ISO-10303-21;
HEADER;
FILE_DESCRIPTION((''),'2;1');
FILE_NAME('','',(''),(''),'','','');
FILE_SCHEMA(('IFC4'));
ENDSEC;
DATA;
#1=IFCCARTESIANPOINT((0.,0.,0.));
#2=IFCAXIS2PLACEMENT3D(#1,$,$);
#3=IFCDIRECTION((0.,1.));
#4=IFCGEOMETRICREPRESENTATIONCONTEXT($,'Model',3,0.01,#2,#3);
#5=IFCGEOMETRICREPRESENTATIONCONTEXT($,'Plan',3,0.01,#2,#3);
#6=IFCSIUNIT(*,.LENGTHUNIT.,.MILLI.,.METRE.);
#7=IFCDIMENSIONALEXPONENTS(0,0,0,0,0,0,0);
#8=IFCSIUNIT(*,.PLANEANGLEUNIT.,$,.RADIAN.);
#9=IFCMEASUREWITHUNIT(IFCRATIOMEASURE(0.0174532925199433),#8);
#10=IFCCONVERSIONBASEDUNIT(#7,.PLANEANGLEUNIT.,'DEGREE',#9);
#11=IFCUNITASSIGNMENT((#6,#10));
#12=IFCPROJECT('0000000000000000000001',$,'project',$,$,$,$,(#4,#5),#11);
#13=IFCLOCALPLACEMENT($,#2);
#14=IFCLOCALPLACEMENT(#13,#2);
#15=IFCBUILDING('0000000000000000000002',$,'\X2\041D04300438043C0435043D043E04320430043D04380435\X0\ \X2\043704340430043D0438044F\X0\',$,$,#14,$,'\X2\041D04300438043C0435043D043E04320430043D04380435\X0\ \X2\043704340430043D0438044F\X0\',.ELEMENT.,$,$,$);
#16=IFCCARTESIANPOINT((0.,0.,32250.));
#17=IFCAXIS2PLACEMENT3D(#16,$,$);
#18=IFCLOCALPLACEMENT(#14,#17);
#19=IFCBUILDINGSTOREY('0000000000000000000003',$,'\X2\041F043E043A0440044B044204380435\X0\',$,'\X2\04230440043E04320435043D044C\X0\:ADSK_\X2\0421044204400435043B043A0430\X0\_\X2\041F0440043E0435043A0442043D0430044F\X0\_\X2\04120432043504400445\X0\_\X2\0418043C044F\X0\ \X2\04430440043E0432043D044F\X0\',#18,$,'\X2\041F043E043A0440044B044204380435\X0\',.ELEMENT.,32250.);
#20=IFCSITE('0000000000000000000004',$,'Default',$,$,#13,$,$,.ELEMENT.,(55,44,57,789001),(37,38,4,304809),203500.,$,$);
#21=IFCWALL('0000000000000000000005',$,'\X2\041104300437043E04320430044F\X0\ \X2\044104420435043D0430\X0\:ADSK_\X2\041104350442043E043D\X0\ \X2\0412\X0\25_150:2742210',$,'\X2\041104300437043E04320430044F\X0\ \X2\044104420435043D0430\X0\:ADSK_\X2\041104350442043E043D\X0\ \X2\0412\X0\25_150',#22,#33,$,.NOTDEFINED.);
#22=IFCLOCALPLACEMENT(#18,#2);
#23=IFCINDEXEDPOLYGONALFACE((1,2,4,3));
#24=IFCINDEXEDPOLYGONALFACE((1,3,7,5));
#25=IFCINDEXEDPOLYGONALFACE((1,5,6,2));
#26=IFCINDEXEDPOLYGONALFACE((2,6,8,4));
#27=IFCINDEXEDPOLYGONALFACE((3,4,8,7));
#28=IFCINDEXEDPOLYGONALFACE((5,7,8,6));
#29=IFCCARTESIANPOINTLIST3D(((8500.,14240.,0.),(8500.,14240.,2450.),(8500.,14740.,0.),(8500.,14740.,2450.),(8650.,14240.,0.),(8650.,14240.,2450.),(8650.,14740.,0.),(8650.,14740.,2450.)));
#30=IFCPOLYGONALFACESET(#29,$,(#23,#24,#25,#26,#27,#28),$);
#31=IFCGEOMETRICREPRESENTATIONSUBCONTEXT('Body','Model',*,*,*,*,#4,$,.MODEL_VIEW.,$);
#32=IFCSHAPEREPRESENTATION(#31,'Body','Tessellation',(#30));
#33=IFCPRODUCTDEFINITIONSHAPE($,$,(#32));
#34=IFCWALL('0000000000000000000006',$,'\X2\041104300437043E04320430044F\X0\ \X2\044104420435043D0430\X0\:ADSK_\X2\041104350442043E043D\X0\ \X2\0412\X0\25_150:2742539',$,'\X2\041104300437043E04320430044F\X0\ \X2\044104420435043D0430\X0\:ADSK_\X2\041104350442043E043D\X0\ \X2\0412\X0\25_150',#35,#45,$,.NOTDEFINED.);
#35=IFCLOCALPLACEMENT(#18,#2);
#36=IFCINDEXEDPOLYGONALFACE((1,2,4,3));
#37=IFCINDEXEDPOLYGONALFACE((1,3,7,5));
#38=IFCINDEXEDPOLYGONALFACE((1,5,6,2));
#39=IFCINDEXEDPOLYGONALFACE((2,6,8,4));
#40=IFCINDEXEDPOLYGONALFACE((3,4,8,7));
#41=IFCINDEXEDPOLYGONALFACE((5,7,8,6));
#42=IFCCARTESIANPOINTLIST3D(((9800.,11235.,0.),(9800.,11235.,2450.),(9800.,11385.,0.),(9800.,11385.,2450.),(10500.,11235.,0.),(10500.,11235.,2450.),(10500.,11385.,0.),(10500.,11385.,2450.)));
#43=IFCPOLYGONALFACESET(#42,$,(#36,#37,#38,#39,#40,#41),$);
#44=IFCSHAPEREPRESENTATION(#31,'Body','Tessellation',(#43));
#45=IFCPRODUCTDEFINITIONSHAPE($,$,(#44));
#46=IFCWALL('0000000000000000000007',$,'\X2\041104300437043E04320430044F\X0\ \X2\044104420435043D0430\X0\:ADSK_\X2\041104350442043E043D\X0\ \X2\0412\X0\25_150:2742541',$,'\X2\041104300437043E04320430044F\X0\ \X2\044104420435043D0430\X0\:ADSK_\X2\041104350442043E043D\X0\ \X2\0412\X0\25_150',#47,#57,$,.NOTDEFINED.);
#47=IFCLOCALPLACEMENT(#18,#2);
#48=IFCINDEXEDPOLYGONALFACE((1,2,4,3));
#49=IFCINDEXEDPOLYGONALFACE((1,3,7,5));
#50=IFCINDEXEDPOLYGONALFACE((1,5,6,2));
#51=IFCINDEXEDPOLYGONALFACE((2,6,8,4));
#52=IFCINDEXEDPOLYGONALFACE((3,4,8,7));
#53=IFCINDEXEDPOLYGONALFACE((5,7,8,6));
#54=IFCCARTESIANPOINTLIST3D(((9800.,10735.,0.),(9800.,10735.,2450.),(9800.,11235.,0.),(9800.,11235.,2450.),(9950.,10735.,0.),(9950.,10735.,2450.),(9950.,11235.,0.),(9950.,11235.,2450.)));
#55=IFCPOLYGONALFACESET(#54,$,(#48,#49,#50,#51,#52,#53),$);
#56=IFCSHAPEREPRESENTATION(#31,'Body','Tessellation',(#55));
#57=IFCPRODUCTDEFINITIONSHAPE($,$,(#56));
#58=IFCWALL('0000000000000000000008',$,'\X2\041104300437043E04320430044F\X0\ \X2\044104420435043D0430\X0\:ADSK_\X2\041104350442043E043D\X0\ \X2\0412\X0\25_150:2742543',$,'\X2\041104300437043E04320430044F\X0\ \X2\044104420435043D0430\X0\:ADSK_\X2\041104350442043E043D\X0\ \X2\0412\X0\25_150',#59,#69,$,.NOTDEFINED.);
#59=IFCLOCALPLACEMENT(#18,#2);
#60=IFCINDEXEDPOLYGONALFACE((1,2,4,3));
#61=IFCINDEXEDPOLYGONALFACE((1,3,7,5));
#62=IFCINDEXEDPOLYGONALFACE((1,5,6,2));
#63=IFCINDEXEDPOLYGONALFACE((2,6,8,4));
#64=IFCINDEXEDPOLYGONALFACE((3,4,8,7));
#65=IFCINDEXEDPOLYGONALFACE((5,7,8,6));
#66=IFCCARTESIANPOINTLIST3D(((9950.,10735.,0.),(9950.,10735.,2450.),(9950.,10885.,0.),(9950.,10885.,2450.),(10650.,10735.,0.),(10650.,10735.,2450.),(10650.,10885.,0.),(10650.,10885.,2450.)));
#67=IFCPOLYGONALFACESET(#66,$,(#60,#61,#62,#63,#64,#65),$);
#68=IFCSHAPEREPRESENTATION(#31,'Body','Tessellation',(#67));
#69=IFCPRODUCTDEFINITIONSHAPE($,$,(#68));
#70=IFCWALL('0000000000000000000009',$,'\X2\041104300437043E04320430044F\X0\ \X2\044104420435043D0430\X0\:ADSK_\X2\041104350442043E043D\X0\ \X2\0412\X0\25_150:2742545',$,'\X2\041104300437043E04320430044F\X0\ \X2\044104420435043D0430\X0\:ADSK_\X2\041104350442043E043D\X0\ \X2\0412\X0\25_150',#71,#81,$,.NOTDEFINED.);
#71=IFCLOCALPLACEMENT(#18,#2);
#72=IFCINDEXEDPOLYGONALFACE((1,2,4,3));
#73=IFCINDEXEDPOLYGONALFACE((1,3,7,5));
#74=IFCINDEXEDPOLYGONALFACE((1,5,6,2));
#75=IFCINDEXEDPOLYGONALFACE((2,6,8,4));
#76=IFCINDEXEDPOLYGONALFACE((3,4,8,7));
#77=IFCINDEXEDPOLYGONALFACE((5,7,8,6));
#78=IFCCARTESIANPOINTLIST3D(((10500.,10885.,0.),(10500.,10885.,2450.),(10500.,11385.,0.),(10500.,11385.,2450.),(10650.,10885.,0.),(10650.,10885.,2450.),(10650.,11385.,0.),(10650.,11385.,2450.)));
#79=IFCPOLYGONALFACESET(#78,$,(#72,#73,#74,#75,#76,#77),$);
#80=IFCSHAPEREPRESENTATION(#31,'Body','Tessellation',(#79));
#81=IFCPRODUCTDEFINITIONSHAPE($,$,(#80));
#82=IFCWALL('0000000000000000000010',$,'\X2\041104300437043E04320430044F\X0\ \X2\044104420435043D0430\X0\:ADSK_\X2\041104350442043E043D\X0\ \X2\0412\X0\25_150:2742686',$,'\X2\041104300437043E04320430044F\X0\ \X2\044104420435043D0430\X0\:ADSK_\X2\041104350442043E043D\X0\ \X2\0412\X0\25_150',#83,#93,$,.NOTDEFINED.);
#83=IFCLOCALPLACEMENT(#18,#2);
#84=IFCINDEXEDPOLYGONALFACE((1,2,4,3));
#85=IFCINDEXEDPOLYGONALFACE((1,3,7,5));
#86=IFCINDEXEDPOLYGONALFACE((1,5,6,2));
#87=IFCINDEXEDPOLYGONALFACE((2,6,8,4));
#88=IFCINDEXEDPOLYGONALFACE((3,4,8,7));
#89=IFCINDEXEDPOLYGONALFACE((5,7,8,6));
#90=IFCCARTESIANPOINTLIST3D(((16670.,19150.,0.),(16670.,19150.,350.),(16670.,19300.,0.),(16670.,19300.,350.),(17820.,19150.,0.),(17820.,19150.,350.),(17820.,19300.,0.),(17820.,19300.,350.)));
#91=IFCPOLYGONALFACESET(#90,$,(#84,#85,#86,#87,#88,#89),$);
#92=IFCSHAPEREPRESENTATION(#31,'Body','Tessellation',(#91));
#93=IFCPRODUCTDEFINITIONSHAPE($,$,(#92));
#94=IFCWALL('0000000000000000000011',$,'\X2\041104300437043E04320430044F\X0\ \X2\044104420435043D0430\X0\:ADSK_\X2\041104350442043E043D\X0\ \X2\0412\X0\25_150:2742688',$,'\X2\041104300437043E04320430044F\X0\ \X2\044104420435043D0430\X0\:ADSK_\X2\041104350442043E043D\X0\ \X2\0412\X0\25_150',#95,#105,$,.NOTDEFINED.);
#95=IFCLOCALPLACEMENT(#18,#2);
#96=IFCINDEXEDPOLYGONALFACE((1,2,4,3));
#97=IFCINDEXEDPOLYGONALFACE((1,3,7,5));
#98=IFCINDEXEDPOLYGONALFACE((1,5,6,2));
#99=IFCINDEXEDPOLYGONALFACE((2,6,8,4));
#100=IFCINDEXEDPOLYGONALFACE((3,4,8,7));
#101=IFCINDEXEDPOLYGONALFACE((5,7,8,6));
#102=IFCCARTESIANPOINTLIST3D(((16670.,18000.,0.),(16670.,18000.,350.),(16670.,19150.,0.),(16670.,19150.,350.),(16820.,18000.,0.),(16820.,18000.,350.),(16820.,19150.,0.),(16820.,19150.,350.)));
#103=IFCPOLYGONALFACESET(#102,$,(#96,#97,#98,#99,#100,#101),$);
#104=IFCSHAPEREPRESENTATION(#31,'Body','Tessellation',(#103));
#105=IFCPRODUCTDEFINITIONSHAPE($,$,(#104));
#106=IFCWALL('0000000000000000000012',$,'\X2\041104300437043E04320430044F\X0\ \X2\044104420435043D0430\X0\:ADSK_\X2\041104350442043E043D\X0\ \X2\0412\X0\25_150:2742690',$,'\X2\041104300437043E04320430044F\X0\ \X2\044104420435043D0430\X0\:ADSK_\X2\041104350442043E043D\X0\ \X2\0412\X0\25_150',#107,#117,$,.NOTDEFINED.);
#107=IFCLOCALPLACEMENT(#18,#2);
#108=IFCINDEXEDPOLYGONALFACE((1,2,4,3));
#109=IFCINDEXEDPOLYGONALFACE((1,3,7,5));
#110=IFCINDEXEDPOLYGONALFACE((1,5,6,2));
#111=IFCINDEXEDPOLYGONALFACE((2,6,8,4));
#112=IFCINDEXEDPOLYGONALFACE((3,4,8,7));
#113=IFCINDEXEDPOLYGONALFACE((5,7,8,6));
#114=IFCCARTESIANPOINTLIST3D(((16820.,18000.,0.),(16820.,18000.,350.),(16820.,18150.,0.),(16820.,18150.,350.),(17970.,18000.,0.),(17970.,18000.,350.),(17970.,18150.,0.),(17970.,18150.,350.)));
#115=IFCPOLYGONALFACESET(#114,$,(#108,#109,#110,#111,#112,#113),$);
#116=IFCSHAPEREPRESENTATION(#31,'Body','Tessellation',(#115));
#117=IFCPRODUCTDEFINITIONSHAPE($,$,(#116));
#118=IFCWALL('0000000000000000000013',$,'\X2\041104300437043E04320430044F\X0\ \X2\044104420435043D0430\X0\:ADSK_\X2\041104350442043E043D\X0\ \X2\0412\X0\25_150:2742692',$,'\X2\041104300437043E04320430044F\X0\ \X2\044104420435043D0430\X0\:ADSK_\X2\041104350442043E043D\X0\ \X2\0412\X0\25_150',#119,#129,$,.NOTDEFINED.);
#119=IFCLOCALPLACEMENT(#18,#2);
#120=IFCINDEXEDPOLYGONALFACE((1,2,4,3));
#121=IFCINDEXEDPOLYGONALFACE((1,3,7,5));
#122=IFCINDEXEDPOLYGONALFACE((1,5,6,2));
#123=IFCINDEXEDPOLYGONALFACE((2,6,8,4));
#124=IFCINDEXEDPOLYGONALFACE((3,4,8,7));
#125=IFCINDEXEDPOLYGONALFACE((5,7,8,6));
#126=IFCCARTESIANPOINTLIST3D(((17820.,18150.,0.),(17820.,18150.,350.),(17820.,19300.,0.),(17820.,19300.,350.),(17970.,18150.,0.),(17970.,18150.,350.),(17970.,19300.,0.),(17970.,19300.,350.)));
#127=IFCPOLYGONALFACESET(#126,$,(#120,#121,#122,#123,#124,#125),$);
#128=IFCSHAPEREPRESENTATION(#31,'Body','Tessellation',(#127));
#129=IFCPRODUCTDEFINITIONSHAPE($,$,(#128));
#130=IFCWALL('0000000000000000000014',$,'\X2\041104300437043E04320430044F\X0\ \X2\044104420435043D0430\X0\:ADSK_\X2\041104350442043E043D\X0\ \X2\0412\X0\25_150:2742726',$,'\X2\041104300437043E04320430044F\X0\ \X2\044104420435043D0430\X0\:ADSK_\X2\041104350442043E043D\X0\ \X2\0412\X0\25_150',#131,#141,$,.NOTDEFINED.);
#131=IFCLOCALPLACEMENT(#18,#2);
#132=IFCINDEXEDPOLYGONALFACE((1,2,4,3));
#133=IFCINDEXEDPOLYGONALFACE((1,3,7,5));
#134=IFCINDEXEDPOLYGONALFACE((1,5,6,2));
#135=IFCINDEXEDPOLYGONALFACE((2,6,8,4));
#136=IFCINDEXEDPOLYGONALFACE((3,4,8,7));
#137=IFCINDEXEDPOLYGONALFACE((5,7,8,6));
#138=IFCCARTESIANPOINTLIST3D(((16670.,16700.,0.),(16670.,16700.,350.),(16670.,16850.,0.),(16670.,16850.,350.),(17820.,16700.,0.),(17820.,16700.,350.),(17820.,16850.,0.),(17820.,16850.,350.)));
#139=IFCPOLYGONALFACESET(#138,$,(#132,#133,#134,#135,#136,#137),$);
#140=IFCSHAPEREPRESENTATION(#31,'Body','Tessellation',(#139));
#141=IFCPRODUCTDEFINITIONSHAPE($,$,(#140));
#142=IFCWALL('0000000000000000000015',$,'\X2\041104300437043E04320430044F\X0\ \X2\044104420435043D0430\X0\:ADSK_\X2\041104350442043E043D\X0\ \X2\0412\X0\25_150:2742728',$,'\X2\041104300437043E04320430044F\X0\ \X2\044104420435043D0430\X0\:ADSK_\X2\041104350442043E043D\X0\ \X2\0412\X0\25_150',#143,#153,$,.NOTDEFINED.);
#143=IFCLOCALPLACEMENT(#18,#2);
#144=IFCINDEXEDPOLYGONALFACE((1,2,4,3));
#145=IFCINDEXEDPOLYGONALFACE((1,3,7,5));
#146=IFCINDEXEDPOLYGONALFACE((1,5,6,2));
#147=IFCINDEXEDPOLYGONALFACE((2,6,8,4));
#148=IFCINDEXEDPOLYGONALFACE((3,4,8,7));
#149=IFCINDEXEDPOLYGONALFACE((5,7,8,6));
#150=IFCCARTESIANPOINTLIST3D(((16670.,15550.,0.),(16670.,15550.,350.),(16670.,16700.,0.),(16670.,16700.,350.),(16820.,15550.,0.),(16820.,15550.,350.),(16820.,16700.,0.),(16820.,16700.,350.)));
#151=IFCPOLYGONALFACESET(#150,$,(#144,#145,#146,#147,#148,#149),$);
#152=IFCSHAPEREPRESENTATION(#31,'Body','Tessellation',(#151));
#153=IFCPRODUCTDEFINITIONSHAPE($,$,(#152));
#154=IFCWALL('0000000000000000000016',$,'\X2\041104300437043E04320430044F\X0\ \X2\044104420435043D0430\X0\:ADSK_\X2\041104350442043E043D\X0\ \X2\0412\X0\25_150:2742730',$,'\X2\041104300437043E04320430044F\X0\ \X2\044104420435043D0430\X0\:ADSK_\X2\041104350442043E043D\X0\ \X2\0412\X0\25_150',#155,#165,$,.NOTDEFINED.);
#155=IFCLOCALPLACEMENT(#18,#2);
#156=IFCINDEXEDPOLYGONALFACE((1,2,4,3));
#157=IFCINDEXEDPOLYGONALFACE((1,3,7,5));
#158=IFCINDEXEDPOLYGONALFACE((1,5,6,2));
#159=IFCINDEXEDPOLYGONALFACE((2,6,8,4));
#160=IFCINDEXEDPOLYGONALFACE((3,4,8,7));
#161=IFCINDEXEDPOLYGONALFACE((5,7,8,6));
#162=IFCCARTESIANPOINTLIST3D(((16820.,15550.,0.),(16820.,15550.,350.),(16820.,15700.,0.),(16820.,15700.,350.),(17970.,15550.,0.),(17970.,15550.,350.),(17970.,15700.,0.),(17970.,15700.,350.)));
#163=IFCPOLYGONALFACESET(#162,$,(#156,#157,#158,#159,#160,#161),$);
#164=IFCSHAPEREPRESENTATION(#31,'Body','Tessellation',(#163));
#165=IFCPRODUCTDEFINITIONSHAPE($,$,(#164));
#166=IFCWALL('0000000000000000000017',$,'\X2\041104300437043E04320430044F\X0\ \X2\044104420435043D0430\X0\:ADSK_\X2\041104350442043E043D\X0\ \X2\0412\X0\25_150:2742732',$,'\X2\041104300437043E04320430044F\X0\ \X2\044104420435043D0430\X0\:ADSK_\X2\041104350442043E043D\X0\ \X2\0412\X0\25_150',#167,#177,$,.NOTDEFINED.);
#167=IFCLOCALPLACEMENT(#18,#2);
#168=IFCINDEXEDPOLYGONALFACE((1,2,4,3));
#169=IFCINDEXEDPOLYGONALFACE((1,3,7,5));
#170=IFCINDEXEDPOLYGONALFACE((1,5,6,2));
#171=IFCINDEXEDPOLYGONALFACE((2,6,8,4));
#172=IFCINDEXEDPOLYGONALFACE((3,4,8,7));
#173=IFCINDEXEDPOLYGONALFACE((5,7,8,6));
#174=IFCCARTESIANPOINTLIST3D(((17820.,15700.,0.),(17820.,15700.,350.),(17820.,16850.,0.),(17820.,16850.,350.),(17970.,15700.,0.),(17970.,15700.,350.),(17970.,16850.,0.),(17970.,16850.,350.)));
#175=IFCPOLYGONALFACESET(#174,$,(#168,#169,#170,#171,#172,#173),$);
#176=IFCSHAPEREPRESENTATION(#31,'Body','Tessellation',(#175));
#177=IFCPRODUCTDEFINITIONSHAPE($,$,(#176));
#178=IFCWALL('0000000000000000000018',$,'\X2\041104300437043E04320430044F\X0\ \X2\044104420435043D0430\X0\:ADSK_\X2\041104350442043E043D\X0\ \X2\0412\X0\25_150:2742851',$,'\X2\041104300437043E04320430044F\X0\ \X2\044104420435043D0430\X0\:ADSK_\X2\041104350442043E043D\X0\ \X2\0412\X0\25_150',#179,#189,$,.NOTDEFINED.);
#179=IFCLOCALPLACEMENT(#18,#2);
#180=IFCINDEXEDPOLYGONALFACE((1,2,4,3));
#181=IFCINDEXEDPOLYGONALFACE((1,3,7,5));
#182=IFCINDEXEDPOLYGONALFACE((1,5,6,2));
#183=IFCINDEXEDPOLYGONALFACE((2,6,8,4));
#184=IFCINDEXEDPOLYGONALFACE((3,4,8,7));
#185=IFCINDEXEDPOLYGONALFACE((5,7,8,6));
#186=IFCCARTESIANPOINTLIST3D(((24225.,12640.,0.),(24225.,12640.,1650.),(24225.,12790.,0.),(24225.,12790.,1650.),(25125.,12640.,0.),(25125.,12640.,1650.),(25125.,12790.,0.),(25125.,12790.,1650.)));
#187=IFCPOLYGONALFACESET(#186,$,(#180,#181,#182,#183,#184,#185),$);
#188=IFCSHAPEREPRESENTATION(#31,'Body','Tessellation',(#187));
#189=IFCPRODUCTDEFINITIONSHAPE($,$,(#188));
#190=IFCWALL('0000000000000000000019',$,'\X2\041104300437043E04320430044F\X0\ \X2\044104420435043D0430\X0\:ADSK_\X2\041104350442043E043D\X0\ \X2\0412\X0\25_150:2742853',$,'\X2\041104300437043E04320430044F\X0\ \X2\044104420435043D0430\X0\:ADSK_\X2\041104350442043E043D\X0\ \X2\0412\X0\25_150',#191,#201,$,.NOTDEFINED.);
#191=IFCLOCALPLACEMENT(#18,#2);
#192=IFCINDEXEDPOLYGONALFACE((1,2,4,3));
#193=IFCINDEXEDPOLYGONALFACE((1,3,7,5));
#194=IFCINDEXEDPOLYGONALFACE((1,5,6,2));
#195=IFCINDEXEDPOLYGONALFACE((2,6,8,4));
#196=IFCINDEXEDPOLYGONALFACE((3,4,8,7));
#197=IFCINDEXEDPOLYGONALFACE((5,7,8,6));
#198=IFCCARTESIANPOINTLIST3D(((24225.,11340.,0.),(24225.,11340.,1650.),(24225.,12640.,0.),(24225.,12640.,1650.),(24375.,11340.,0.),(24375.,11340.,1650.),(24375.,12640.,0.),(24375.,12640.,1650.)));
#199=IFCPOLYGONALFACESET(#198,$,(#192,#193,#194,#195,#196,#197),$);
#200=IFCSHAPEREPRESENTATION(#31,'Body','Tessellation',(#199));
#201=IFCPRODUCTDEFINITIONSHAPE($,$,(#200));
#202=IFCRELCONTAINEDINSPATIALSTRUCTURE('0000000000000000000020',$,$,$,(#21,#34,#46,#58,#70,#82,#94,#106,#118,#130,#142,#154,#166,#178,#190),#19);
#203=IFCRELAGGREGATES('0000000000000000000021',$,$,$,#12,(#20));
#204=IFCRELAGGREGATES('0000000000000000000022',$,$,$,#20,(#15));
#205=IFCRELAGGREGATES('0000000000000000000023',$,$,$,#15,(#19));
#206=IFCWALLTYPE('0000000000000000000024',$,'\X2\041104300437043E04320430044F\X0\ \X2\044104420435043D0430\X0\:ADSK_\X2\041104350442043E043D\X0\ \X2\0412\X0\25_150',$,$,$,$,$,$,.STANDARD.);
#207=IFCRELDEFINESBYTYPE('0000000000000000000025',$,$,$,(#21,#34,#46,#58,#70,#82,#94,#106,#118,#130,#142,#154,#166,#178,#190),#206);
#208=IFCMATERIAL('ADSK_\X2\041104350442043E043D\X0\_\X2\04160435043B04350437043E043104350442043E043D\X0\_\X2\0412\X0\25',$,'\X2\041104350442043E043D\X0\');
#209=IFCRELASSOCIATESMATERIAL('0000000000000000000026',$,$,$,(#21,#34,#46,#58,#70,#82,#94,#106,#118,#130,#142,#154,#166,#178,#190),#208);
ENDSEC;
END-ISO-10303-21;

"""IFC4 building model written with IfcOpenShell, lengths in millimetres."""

from ifc_helpers import new_model, entity, si_unit, converted_unit, direction, frame, origin, place, context, subcontext, project, spatial, indexed_curve, outline, extrude, material, type_object, element, save


model = new_model("IFC4")

# Units and contexts
model_context = context("Model", 3, precision=0.01, world=origin(), true_north=direction((0.0, 1.0)))
plan_context = context("Plan", 3, precision=0.01, world=origin(), true_north=direction((0.0, 1.0)))
body_context = subcontext(model_context, "Body", "Model", "MODEL_VIEW")
ifc_project = project(units=[si_unit("LENGTHUNIT", "METRE", prefix="MILLI"), converted_unit("PLANEANGLEUNIT", "DEGREE", entity("IfcRatioMeasure", 0.0174532925199433), si_unit("PLANEANGLEUNIT", "RADIAN"), dimensions=[0, 0, 0, 0, 0, 0, 0])], contexts=[model_context, plan_context])

# Site, building, storey
site_placement = place(None, origin())
site = spatial("IfcSite", under=ifc_project, at=site_placement, Name="Default", CompositionType="ELEMENT", RefLatitude=(55, 44, 57, 789001), RefLongitude=(37, 38, 4, 304809), RefElevation=203500.0)
building_placement = place(site_placement, origin())
building = spatial("IfcBuilding", under=site, at=building_placement, Name="Наименование здания", LongName="Наименование здания", CompositionType="ELEMENT")
storey_placement = place(building_placement, frame((0.0, 0.0, 32250.0)))
storey = spatial("IfcBuildingStorey", under=building, at=storey_placement, Name="Покрытие", ObjectType="Уровень:ADSK_Стрелка_Проектная_Вверх_Имя уровня", LongName="Покрытие", CompositionType="ELEMENT", Elevation=32250.0)

# Walls
ifc_material = material(Name="ADSK_Бетон_Железобетон_В25", Category="Бетон")
wall_type_1 = type_object("IfcWallType", Name="Базовая стена:ADSK_Бетон В25_150", PredefinedType="STANDARD")
for number, where, z_axis, x_axis, name in (
    (1, (8575.0, 14740.0, 0.0), (0.0, 0.0, 1.0), (0.0, -1.0, 0.0), "Базовая стена:ADSK_Бетон В25_150:2742210"),
):
    element("IfcWall", number, at=place(storey_placement, frame(where, z_axis=z_axis, x_axis=x_axis)), inside=storey, type_object=wall_type_1, material=ifc_material, Name=name, ObjectType="Базовая стена:ADSK_Бетон В25_150", PredefinedType="NOTDEFINED", context=body_context, shape_type="SweptSolid", body=[
        extrude(outline(indexed_curve([(500.0, 75.0), (0.0, 75.0), (0.0, -75.0), (500.0, -75.0), (500.0, 75.0)], self_intersect=False)), origin(), (0.0, 0.0, 1.0), 2450.0),
    ])
wall_1_placement = place(storey_placement, frame((9800.0, 11310.0, 0.0)))
element("IfcWall", 2, at=wall_1_placement, inside=storey, type_object=wall_type_1, material=ifc_material, Name="Базовая стена:ADSK_Бетон В25_150:2742539", ObjectType="Базовая стена:ADSK_Бетон В25_150", PredefinedType="NOTDEFINED", context=body_context, shape_type="SweptSolid", body=[
    extrude(outline(indexed_curve([(700.0, 75.0), (0.0, 75.0), (0.0, -75.0), (700.0, -75.0), (700.0, 75.0)], self_intersect=False)), origin(), (0.0, 0.0, 1.0), 2450.0),
])
wall_2_placement = place(storey_placement, frame((9875.0, 10735.0, 0.0), z_axis=(0.0, 0.0, 1.0), x_axis=(0.0, 1.0, 0.0)))
element("IfcWall", 3, at=wall_2_placement, inside=storey, type_object=wall_type_1, material=ifc_material, Name="Базовая стена:ADSK_Бетон В25_150:2742541", ObjectType="Базовая стена:ADSK_Бетон В25_150", PredefinedType="NOTDEFINED", context=body_context, shape_type="SweptSolid", body=[
    extrude(outline(indexed_curve([(500.0, 75.0), (0.0, 75.0), (0.0, -75.0), (500.0, -75.0), (500.0, 75.0)], self_intersect=False)), origin(), (0.0, 0.0, 1.0), 2450.0),
])
wall_3_placement = place(storey_placement, frame((10650.0, 10810.0, 0.0), z_axis=(0.0, 0.0, 1.0), x_axis=(-1.0, 0.0, 0.0)))
element("IfcWall", 4, at=wall_3_placement, inside=storey, type_object=wall_type_1, material=ifc_material, Name="Базовая стена:ADSK_Бетон В25_150:2742543", ObjectType="Базовая стена:ADSK_Бетон В25_150", PredefinedType="NOTDEFINED", context=body_context, shape_type="SweptSolid", body=[
    extrude(outline(indexed_curve([(700.0, 75.0), (0.0, 75.0), (0.0, -75.0), (700.0, -75.0), (700.0, 75.0)], self_intersect=False)), origin(), (0.0, 0.0, 1.0), 2450.0),
])
wall_4_placement = place(storey_placement, frame((10575.0, 11385.0, 0.0), z_axis=(0.0, 0.0, 1.0), x_axis=(0.0, -1.0, 0.0)))
element("IfcWall", 5, at=wall_4_placement, inside=storey, type_object=wall_type_1, material=ifc_material, Name="Базовая стена:ADSK_Бетон В25_150:2742545", ObjectType="Базовая стена:ADSK_Бетон В25_150", PredefinedType="NOTDEFINED", context=body_context, shape_type="SweptSolid", body=[
    extrude(outline(indexed_curve([(500.0, 75.0), (0.0, 75.0), (0.0, -75.0), (500.0, -75.0), (500.0, 75.0)], self_intersect=False)), origin(), (0.0, 0.0, 1.0), 2450.0),
])
wall_5_placement = place(storey_placement, frame((16670.0, 19225.0, 0.0)))
element("IfcWall", 6, at=wall_5_placement, inside=storey, type_object=wall_type_1, material=ifc_material, Name="Базовая стена:ADSK_Бетон В25_150:2742686", ObjectType="Базовая стена:ADSK_Бетон В25_150", PredefinedType="NOTDEFINED", context=body_context, shape_type="SweptSolid", body=[
    extrude(outline(indexed_curve([(1150.0, 75.0), (0.0, 75.0), (0.0, -75.0), (1150.0, -75.0), (1150.0, 75.0)], self_intersect=False)), origin(), (0.0, 0.0, 1.0), 350.0),
])
for number, where, z_axis, x_axis, name in (
    (7, (16745.0, 18000.0, 0.0), (0.0, 0.0, 1.0), (0.0, 1.0, 0.0), "Базовая стена:ADSK_Бетон В25_150:2742688"),
    (8, (17970.0, 18075.0, 0.0), (0.0, 0.0, 1.0), (-1.0, 0.0, 0.0), "Базовая стена:ADSK_Бетон В25_150:2742690"),
    (9, (17895.0, 19300.0, 0.0), (0.0, 0.0, 1.0), (0.0, -1.0, 0.0), "Базовая стена:ADSK_Бетон В25_150:2742692"),
):
    element("IfcWall", number, at=place(storey_placement, frame(where, z_axis=z_axis, x_axis=x_axis)), inside=storey, type_object=wall_type_1, material=ifc_material, Name=name, ObjectType="Базовая стена:ADSK_Бетон В25_150", PredefinedType="NOTDEFINED", context=body_context, shape_type="SweptSolid", body=[
        extrude(outline(indexed_curve([(1150.0, 75.0), (0.0, 75.0), (0.0, -75.0), (1150.0, -75.0), (1150.0, 75.0)], self_intersect=False)), origin(), (0.0, 0.0, 1.0), 350.0),
    ])
wall_6_placement = place(storey_placement, frame((16670.0, 16775.0, 0.0)))
element("IfcWall", 10, at=wall_6_placement, inside=storey, type_object=wall_type_1, material=ifc_material, Name="Базовая стена:ADSK_Бетон В25_150:2742726", ObjectType="Базовая стена:ADSK_Бетон В25_150", PredefinedType="NOTDEFINED", context=body_context, shape_type="SweptSolid", body=[
    extrude(outline(indexed_curve([(1150.0, 75.0), (0.0, 75.0), (0.0, -75.0), (1150.0, -75.0), (1150.0, 75.0)], self_intersect=False)), origin(), (0.0, 0.0, 1.0), 350.0),
])
for number, where, z_axis, x_axis, name in (
    (11, (16745.0, 15550.0, 0.0), (0.0, 0.0, 1.0), (0.0, 1.0, 0.0), "Базовая стена:ADSK_Бетон В25_150:2742728"),
    (12, (17970.0, 15625.0, 0.0), (0.0, 0.0, 1.0), (-1.0, 0.0, 0.0), "Базовая стена:ADSK_Бетон В25_150:2742730"),
    (13, (17895.0, 16850.0, 0.0), (0.0, 0.0, 1.0), (0.0, -1.0, 0.0), "Базовая стена:ADSK_Бетон В25_150:2742732"),
):
    element("IfcWall", number, at=place(storey_placement, frame(where, z_axis=z_axis, x_axis=x_axis)), inside=storey, type_object=wall_type_1, material=ifc_material, Name=name, ObjectType="Базовая стена:ADSK_Бетон В25_150", PredefinedType="NOTDEFINED", context=body_context, shape_type="SweptSolid", body=[
        extrude(outline(indexed_curve([(1150.0, 75.0), (0.0, 75.0), (0.0, -75.0), (1150.0, -75.0), (1150.0, 75.0)], self_intersect=False)), origin(), (0.0, 0.0, 1.0), 350.0),
    ])
wall_7_placement = place(storey_placement, frame((24225.0, 12715.0, 0.0)))
element("IfcWall", 14, at=wall_7_placement, inside=storey, type_object=wall_type_1, material=ifc_material, Name="Базовая стена:ADSK_Бетон В25_150:2742851", ObjectType="Базовая стена:ADSK_Бетон В25_150", PredefinedType="NOTDEFINED", context=body_context, shape_type="SweptSolid", body=[
    extrude(outline(indexed_curve([(900.0, 75.0), (0.0, 75.0), (0.0, -75.0), (900.0, -75.0), (900.0, 75.0)], self_intersect=False)), origin(), (0.0, 0.0, 1.0), 1650.0),
])
wall_8_placement = place(storey_placement, frame((24300.0, 11340.0, 0.0), z_axis=(0.0, 0.0, 1.0), x_axis=(0.0, 1.0, 0.0)))
element("IfcWall", 15, at=wall_8_placement, inside=storey, type_object=wall_type_1, material=ifc_material, Name="Базовая стена:ADSK_Бетон В25_150:2742853", ObjectType="Базовая стена:ADSK_Бетон В25_150", PredefinedType="NOTDEFINED", context=body_context, shape_type="SweptSolid", body=[
    extrude(outline(indexed_curve([(1300.0, 75.0), (0.0, 75.0), (0.0, -75.0), (1300.0, -75.0), (1300.0, 75.0)], self_intersect=False)), origin(), (0.0, 0.0, 1.0), 1650.0),
])

save(model, "model.ifc")
